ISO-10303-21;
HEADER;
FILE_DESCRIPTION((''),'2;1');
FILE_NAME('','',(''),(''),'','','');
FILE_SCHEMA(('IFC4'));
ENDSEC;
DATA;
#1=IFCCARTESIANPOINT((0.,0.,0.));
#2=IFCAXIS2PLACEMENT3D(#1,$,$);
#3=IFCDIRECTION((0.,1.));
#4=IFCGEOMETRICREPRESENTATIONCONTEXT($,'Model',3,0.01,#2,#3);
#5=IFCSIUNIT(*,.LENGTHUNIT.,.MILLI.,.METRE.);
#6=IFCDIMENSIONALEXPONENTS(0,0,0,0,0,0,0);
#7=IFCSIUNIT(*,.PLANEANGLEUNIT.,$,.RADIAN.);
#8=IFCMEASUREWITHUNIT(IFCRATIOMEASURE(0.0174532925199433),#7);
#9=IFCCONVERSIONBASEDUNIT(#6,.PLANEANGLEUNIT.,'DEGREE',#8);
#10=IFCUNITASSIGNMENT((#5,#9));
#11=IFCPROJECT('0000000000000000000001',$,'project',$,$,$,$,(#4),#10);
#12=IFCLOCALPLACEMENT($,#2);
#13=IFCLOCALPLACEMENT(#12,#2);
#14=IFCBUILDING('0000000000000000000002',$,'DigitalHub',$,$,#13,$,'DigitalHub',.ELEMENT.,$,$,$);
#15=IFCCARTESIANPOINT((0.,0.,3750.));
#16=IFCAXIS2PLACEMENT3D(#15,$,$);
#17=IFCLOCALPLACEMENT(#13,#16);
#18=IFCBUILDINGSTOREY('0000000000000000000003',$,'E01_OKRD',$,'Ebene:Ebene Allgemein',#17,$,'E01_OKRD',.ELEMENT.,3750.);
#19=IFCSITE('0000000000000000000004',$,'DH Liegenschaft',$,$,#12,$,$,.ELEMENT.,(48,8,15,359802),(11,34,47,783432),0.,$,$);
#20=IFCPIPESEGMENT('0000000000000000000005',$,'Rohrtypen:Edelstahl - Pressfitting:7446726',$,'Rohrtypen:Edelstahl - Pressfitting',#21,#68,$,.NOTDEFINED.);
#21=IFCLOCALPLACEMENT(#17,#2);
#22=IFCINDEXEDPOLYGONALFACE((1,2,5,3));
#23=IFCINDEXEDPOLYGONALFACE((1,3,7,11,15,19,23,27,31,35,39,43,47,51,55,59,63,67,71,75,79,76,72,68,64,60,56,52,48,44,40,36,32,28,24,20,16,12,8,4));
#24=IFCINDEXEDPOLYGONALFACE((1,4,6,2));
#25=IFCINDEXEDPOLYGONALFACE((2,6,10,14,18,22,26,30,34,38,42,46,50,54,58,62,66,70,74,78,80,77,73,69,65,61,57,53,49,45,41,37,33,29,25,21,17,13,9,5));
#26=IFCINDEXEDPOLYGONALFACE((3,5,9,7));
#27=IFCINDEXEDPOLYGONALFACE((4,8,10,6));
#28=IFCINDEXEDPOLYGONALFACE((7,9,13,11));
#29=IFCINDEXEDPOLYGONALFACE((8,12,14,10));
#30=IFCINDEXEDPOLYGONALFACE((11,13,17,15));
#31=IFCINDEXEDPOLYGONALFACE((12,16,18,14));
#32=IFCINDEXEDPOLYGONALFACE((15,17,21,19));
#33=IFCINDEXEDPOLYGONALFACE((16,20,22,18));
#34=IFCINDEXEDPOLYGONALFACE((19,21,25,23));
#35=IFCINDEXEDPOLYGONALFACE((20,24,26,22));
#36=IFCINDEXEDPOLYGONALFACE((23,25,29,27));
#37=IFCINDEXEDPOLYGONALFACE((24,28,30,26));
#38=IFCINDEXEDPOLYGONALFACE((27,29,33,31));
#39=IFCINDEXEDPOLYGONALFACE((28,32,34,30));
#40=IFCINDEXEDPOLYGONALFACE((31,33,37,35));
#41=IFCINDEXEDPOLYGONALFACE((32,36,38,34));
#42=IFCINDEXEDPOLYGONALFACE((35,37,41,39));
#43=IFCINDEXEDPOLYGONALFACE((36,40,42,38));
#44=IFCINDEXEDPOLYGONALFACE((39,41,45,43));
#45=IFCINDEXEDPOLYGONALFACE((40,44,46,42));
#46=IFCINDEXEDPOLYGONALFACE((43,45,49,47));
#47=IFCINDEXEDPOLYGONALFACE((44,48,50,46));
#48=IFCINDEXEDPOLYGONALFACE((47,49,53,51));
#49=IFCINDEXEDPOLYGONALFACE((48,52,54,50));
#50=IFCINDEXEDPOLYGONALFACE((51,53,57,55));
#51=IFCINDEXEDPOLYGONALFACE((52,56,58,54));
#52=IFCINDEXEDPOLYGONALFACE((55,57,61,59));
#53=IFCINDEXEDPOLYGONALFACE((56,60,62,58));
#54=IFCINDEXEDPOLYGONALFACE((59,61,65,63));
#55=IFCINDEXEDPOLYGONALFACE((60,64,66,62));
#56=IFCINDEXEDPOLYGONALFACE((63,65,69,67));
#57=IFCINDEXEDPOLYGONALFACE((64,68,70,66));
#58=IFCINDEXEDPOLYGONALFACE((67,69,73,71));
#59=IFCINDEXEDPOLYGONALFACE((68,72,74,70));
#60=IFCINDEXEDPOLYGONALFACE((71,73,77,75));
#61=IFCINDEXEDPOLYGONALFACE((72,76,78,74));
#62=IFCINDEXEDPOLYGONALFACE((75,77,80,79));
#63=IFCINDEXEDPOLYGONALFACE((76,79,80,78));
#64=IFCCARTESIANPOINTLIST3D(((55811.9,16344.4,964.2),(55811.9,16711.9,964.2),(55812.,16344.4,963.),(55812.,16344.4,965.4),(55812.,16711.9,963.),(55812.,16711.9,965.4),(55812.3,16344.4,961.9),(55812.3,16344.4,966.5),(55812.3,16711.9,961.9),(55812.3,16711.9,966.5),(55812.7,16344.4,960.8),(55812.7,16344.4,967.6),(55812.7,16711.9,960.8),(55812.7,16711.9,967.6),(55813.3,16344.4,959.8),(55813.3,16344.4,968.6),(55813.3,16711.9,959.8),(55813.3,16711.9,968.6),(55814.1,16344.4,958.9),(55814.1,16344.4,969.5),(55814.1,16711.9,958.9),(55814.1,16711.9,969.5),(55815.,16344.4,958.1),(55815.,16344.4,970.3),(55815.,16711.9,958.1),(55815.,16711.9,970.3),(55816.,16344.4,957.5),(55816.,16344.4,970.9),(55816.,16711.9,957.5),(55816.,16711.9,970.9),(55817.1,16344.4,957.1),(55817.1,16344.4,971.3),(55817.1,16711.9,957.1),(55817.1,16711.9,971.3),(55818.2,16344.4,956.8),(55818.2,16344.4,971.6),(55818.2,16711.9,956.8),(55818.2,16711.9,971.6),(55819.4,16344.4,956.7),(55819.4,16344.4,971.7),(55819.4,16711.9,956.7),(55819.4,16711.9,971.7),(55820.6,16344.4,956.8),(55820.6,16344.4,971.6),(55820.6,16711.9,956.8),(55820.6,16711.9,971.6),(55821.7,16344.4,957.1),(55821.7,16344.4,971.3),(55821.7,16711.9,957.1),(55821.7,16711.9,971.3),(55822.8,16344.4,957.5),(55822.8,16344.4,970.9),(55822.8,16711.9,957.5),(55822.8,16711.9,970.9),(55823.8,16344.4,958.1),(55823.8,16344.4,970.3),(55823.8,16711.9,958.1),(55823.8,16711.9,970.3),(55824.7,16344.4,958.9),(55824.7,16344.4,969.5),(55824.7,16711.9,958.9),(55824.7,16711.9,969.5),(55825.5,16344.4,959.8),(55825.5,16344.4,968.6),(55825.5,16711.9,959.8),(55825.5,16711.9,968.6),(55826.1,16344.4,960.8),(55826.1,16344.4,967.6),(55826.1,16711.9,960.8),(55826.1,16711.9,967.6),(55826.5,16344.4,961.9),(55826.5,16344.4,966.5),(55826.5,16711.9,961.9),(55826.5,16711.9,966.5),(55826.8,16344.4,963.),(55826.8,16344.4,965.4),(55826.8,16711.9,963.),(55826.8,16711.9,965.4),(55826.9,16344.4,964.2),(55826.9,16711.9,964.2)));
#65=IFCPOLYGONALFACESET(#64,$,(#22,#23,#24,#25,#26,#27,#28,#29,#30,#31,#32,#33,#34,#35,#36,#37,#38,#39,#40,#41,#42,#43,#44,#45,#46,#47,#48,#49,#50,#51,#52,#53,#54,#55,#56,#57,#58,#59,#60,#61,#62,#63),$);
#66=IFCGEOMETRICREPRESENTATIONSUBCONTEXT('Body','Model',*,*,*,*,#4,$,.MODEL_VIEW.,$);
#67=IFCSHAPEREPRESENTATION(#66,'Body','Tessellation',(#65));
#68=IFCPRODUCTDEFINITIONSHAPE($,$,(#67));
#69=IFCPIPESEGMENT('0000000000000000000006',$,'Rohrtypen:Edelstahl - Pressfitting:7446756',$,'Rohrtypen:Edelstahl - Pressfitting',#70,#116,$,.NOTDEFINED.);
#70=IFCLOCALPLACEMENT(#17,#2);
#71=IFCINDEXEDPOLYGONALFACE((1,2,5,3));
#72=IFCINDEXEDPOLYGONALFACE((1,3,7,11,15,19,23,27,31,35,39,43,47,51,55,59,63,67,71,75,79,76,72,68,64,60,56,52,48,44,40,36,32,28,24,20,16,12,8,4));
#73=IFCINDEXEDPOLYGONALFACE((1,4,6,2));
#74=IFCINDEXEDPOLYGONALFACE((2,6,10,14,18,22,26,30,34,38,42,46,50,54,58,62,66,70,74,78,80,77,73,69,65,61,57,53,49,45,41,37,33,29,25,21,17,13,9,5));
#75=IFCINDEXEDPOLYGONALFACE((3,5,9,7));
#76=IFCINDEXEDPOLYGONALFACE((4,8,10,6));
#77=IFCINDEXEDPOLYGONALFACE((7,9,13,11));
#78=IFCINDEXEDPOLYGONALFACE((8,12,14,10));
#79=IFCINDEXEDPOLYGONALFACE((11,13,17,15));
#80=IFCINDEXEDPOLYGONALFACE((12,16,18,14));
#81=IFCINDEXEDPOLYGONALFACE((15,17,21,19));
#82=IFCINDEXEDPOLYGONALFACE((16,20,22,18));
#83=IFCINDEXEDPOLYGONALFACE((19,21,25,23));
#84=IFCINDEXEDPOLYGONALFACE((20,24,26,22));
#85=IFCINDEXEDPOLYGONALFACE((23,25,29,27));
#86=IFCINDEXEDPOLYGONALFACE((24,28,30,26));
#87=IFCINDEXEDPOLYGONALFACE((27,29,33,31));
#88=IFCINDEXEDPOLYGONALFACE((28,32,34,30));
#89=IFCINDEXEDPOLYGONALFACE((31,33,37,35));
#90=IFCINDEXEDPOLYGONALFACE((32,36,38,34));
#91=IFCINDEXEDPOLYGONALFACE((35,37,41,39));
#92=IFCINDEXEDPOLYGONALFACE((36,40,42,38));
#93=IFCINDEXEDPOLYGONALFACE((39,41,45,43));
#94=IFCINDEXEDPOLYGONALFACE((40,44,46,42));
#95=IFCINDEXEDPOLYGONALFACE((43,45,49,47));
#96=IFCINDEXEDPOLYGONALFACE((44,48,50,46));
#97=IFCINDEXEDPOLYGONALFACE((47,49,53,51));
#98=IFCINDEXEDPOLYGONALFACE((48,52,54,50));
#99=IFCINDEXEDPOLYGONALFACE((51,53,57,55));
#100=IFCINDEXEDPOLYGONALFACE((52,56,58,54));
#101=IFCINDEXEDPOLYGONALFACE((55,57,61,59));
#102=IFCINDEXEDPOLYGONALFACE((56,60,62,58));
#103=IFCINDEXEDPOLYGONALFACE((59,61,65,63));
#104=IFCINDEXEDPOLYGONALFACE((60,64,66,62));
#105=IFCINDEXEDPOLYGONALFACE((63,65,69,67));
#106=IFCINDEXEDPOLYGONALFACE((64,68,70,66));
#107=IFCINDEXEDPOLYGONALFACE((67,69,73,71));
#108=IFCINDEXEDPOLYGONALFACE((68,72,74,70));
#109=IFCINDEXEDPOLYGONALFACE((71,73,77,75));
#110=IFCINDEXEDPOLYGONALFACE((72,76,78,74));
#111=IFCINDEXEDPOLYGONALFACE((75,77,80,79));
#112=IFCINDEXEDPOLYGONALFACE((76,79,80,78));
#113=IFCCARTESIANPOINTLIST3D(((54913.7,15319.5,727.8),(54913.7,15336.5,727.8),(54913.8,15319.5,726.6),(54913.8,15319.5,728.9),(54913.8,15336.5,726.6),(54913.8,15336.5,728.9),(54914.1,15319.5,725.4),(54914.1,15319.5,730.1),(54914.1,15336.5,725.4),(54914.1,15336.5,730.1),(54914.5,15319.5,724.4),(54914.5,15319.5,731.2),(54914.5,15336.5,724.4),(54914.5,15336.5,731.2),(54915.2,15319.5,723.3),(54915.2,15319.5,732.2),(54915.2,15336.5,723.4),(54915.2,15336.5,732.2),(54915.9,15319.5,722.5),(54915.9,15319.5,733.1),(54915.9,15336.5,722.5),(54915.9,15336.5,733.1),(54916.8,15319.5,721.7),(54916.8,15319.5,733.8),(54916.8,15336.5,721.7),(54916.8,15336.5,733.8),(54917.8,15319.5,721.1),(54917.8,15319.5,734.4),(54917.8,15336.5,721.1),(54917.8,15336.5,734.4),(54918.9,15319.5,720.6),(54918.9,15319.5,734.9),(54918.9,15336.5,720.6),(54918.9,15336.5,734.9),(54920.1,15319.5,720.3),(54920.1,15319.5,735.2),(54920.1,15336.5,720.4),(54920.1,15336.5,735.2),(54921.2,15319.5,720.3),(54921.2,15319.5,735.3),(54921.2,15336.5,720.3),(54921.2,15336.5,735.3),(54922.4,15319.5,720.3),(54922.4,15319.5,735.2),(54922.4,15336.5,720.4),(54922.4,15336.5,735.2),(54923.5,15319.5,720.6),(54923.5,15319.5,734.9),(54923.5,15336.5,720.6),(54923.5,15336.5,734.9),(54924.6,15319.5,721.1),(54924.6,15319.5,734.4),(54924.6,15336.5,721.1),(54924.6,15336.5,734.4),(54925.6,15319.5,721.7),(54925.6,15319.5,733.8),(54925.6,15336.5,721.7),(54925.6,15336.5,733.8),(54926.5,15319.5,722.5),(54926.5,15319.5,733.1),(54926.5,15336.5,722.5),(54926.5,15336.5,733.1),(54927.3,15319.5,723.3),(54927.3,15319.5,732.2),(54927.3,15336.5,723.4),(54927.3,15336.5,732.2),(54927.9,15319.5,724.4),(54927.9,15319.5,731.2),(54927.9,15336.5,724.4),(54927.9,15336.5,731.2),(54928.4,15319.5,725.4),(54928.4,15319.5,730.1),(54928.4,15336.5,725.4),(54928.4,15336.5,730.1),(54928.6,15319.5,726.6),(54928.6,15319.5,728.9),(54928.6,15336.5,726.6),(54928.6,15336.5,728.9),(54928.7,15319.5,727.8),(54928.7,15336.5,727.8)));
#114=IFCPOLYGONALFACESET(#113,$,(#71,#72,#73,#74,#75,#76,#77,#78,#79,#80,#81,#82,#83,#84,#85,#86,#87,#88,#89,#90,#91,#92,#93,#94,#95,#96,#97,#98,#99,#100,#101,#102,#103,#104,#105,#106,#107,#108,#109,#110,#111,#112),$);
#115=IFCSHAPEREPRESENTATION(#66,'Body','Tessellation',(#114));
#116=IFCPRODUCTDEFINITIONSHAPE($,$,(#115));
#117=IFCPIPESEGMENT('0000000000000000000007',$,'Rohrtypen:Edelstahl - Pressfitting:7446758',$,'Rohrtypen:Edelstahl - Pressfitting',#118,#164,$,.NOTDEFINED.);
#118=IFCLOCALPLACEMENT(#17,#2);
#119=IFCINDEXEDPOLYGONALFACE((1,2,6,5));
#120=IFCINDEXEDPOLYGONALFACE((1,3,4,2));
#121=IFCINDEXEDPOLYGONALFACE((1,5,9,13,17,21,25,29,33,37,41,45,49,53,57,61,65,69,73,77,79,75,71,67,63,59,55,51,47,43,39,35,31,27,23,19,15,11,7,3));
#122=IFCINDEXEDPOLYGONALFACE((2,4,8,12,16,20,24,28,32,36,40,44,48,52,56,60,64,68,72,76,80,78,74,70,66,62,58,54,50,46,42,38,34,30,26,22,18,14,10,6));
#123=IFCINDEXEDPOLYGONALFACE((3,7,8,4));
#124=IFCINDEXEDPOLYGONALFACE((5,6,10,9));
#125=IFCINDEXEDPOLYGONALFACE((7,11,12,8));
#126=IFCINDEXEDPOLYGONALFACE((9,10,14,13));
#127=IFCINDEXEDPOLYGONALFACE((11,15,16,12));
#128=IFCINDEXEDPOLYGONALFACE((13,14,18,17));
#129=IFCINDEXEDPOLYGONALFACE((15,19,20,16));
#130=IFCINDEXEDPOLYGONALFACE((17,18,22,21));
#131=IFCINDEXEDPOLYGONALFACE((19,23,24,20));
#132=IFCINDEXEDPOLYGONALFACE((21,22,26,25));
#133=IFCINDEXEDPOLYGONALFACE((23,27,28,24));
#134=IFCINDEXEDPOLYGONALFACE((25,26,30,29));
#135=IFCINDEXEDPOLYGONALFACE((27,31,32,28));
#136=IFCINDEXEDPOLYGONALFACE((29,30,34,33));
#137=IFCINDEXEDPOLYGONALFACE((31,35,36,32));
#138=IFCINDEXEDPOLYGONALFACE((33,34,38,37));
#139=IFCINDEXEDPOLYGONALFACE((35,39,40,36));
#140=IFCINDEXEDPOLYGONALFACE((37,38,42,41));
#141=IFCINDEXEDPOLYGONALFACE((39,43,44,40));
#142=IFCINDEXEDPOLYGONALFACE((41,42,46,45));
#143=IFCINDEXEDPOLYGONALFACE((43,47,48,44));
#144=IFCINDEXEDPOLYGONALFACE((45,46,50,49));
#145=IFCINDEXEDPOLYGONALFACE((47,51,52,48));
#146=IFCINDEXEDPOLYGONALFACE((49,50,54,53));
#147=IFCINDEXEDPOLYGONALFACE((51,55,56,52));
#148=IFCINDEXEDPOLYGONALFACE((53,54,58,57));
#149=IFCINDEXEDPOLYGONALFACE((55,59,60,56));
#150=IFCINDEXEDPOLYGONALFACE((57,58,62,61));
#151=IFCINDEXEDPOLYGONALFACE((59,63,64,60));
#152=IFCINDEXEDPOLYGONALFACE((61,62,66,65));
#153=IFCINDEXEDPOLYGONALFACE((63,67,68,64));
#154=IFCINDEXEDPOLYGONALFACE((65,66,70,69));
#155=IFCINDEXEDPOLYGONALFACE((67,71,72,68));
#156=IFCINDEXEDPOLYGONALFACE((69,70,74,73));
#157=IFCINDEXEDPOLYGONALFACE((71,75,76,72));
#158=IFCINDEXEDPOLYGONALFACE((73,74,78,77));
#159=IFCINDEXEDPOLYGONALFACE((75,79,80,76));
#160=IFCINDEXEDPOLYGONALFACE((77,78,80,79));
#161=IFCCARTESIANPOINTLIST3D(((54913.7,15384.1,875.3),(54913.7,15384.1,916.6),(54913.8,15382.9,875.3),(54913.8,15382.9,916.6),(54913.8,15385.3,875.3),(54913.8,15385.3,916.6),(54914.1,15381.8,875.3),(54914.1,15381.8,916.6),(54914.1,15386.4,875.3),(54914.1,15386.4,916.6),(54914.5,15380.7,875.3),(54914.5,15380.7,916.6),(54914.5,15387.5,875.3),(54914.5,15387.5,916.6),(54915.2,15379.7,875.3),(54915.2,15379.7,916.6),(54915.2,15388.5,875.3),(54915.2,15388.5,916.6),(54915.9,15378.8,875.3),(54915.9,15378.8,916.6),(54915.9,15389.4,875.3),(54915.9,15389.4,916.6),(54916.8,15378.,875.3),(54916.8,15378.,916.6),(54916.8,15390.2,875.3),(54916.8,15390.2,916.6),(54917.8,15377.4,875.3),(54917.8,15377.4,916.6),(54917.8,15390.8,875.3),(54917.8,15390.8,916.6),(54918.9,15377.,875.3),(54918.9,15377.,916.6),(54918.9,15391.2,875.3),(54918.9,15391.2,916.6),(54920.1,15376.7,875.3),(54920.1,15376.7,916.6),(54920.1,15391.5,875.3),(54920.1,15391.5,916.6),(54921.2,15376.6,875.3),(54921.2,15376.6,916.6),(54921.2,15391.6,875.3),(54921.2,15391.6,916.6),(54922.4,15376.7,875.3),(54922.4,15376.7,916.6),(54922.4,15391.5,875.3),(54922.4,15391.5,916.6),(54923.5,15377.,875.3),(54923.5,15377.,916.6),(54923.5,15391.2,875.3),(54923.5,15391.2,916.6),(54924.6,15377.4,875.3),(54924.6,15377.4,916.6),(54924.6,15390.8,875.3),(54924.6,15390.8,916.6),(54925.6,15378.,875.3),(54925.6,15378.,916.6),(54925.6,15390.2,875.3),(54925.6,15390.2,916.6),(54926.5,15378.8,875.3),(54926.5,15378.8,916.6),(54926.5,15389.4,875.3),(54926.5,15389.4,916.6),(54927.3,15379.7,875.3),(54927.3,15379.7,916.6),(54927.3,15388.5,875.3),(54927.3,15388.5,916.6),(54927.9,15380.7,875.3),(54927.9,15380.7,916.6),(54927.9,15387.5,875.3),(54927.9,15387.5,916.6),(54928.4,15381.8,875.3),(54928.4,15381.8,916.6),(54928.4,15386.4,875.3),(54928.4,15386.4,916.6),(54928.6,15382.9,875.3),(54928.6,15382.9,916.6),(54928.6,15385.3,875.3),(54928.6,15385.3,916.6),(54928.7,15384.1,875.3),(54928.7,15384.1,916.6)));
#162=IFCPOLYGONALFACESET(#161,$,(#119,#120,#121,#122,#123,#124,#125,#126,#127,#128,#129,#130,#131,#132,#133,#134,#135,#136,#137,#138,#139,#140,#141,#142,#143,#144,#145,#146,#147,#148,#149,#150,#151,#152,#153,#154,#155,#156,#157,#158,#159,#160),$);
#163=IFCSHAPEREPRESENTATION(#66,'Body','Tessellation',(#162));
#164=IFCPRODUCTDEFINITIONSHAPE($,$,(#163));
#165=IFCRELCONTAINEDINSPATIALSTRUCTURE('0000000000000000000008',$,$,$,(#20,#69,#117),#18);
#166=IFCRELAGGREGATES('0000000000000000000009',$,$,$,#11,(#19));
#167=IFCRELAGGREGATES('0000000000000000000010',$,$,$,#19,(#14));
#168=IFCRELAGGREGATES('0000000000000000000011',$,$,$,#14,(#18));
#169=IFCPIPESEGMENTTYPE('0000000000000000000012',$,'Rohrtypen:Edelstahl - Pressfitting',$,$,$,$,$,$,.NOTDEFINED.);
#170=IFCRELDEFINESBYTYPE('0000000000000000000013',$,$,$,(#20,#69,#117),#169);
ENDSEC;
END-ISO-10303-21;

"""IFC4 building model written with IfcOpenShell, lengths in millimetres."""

from ifc_helpers import new_model, entity, si_unit, converted_unit, direction, frame, origin, place, context, subcontext, project, spatial, indexed_curve, outline, extrude, type_object, element, save


model = new_model("IFC4")

# Units and contexts
model_context = context("Model", 3, precision=0.01, world=origin(), true_north=direction((0.0, 1.0)))
body_context = subcontext(model_context, "Body", "Model", "MODEL_VIEW")
ifc_project = project(units=[si_unit("LENGTHUNIT", "METRE", prefix="MILLI"), converted_unit("PLANEANGLEUNIT", "DEGREE", entity("IfcRatioMeasure", 0.0174532925199433), si_unit("PLANEANGLEUNIT", "RADIAN"), dimensions=[0, 0, 0, 0, 0, 0, 0])], contexts=[model_context])

# Site, building, storey
site_placement = place(None, origin())
site = spatial("IfcSite", under=ifc_project, at=site_placement, Name="DH Liegenschaft", CompositionType="ELEMENT", RefLatitude=(48, 8, 15, 359802), RefLongitude=(11, 34, 47, 783432), RefElevation=0.0)
building_placement = place(site_placement, origin())
building = spatial("IfcBuilding", under=site, at=building_placement, Name="DigitalHub", LongName="DigitalHub", CompositionType="ELEMENT")
storey_placement = place(building_placement, frame((0.0, 0.0, 3750.0)))
storey = spatial("IfcBuildingStorey", under=building, at=storey_placement, Name="E01_OKRD", ObjectType="Ebene:Ebene Allgemein", LongName="E01_OKRD", CompositionType="ELEMENT", Elevation=3750.0)

# Pipe segments
pipe_segment_type_1 = type_object("IfcPipeSegmentType", Name="Rohrtypen:Edelstahl - Pressfitting", PredefinedType="NOTDEFINED")
pipe_segment_1_placement = place(storey_placement, frame((55810.3, 16344.4, 955.1)))
element("IfcPipeSegment", 1, at=pipe_segment_1_placement, inside=storey, type_object=pipe_segment_type_1, Name="Rohrtypen:Edelstahl - Pressfitting:7446726", ObjectType="Rohrtypen:Edelstahl - Pressfitting", PredefinedType="NOTDEFINED", context=body_context, shape_type="SweptSolid", body=[
    extrude(outline(indexed_curve([(7.5, 0.0), (7.4, 1.2), (7.1, 2.3), (6.7, 3.4), (6.1, 4.4), (5.3, 5.3), (4.4, 6.1), (3.4, 6.7), (2.3, 7.1), (1.2, 7.4), (0.0, 7.5), (-1.2, 7.4), (-2.3, 7.1), (-3.4, 6.7), (-4.4, 6.1), (-5.3, 5.3), (-6.1, 4.4), (-6.7, 3.4), (-7.1, 2.3), (-7.4, 1.2), (-7.5, 0.0), (-7.4, -1.2), (-7.1, -2.3), (-6.7, -3.4), (-6.1, -4.4), (-5.3, -5.3), (-4.4, -6.1), (-3.4, -6.7), (-2.3, -7.1), (-1.2, -7.4), (0.0, -7.5), (1.2, -7.4), (2.3, -7.1), (3.4, -6.7), (4.4, -6.1), (5.3, -5.3), (6.1, -4.4), (6.7, -3.4), (7.1, -2.3), (7.4, -1.2), (7.5, 0.0)], self_intersect=False)), frame((9.1, 0.0, 9.1), z_axis=(0.0, 1.0, 0.0), x_axis=(1.0, 0.0, 0.0)), (0.0, 0.0, 1.0), 367.4),
])
pipe_segment_2_placement = place(storey_placement, frame((54912.1, 15319.5, 718.7)))
element("IfcPipeSegment", 2, at=pipe_segment_2_placement, inside=storey, type_object=pipe_segment_type_1, Name="Rohrtypen:Edelstahl - Pressfitting:7446756", ObjectType="Rohrtypen:Edelstahl - Pressfitting", PredefinedType="NOTDEFINED", context=body_context, shape_type="SweptSolid", body=[
    extrude(outline(indexed_curve([(7.5, 0.0), (7.4, 1.2), (7.1, 2.3), (6.7, 3.4), (6.1, 4.4), (5.3, 5.3), (4.4, 6.1), (3.4, 6.7), (2.3, 7.1), (1.2, 7.4), (0.0, 7.5), (-1.2, 7.4), (-2.3, 7.1), (-3.4, 6.7), (-4.4, 6.1), (-5.3, 5.3), (-6.1, 4.4), (-6.7, 3.4), (-7.1, 2.3), (-7.4, 1.2), (-7.5, 0.0), (-7.4, -1.2), (-7.1, -2.3), (-6.7, -3.4), (-6.1, -4.4), (-5.3, -5.3), (-4.4, -6.1), (-3.4, -6.7), (-2.3, -7.1), (-1.2, -7.4), (0.0, -7.5), (1.2, -7.4), (2.3, -7.1), (3.4, -6.7), (4.4, -6.1), (5.3, -5.3), (6.1, -4.4), (6.7, -3.4), (7.1, -2.3), (7.4, -1.2), (7.5, 0.0)], self_intersect=False)), frame((9.1, 0.0, 9.1), z_axis=(0.0, 1.0, 0.00053), x_axis=(1.0, 0.0, 0.0)), (0.0, 0.0, 1.0), 17.0),
])
pipe_segment_3_placement = place(storey_placement, frame((54912.1, 15375.0, 875.3)))
element("IfcPipeSegment", 3, at=pipe_segment_3_placement, inside=storey, type_object=pipe_segment_type_1, Name="Rohrtypen:Edelstahl - Pressfitting:7446758", ObjectType="Rohrtypen:Edelstahl - Pressfitting", PredefinedType="NOTDEFINED", context=body_context, shape_type="SweptSolid", body=[
    extrude(outline(indexed_curve([(7.5, 0.0), (7.4, 1.2), (7.1, 2.3), (6.7, 3.4), (6.1, 4.4), (5.3, 5.3), (4.4, 6.1), (3.4, 6.7), (2.3, 7.1), (1.2, 7.4), (0.0, 7.5), (-1.2, 7.4), (-2.3, 7.1), (-3.4, 6.7), (-4.4, 6.1), (-5.3, 5.3), (-6.1, 4.4), (-6.7, 3.4), (-7.1, 2.3), (-7.4, 1.2), (-7.5, 0.0), (-7.4, -1.2), (-7.1, -2.3), (-6.7, -3.4), (-6.1, -4.4), (-5.3, -5.3), (-4.4, -6.1), (-3.4, -6.7), (-2.3, -7.1), (-1.2, -7.4), (0.0, -7.5), (1.2, -7.4), (2.3, -7.1), (3.4, -6.7), (4.4, -6.1), (5.3, -5.3), (6.1, -4.4), (6.7, -3.4), (7.1, -2.3), (7.4, -1.2), (7.5, 0.0)], self_intersect=False)), frame((9.1, 9.1, 0.0), z_axis=(0.0, 0.0, 1.0), x_axis=(-1.0, 0.0, 0.0)), (0.0, 0.0, 1.0), 41.3),
])

save(model, "model.ifc")
